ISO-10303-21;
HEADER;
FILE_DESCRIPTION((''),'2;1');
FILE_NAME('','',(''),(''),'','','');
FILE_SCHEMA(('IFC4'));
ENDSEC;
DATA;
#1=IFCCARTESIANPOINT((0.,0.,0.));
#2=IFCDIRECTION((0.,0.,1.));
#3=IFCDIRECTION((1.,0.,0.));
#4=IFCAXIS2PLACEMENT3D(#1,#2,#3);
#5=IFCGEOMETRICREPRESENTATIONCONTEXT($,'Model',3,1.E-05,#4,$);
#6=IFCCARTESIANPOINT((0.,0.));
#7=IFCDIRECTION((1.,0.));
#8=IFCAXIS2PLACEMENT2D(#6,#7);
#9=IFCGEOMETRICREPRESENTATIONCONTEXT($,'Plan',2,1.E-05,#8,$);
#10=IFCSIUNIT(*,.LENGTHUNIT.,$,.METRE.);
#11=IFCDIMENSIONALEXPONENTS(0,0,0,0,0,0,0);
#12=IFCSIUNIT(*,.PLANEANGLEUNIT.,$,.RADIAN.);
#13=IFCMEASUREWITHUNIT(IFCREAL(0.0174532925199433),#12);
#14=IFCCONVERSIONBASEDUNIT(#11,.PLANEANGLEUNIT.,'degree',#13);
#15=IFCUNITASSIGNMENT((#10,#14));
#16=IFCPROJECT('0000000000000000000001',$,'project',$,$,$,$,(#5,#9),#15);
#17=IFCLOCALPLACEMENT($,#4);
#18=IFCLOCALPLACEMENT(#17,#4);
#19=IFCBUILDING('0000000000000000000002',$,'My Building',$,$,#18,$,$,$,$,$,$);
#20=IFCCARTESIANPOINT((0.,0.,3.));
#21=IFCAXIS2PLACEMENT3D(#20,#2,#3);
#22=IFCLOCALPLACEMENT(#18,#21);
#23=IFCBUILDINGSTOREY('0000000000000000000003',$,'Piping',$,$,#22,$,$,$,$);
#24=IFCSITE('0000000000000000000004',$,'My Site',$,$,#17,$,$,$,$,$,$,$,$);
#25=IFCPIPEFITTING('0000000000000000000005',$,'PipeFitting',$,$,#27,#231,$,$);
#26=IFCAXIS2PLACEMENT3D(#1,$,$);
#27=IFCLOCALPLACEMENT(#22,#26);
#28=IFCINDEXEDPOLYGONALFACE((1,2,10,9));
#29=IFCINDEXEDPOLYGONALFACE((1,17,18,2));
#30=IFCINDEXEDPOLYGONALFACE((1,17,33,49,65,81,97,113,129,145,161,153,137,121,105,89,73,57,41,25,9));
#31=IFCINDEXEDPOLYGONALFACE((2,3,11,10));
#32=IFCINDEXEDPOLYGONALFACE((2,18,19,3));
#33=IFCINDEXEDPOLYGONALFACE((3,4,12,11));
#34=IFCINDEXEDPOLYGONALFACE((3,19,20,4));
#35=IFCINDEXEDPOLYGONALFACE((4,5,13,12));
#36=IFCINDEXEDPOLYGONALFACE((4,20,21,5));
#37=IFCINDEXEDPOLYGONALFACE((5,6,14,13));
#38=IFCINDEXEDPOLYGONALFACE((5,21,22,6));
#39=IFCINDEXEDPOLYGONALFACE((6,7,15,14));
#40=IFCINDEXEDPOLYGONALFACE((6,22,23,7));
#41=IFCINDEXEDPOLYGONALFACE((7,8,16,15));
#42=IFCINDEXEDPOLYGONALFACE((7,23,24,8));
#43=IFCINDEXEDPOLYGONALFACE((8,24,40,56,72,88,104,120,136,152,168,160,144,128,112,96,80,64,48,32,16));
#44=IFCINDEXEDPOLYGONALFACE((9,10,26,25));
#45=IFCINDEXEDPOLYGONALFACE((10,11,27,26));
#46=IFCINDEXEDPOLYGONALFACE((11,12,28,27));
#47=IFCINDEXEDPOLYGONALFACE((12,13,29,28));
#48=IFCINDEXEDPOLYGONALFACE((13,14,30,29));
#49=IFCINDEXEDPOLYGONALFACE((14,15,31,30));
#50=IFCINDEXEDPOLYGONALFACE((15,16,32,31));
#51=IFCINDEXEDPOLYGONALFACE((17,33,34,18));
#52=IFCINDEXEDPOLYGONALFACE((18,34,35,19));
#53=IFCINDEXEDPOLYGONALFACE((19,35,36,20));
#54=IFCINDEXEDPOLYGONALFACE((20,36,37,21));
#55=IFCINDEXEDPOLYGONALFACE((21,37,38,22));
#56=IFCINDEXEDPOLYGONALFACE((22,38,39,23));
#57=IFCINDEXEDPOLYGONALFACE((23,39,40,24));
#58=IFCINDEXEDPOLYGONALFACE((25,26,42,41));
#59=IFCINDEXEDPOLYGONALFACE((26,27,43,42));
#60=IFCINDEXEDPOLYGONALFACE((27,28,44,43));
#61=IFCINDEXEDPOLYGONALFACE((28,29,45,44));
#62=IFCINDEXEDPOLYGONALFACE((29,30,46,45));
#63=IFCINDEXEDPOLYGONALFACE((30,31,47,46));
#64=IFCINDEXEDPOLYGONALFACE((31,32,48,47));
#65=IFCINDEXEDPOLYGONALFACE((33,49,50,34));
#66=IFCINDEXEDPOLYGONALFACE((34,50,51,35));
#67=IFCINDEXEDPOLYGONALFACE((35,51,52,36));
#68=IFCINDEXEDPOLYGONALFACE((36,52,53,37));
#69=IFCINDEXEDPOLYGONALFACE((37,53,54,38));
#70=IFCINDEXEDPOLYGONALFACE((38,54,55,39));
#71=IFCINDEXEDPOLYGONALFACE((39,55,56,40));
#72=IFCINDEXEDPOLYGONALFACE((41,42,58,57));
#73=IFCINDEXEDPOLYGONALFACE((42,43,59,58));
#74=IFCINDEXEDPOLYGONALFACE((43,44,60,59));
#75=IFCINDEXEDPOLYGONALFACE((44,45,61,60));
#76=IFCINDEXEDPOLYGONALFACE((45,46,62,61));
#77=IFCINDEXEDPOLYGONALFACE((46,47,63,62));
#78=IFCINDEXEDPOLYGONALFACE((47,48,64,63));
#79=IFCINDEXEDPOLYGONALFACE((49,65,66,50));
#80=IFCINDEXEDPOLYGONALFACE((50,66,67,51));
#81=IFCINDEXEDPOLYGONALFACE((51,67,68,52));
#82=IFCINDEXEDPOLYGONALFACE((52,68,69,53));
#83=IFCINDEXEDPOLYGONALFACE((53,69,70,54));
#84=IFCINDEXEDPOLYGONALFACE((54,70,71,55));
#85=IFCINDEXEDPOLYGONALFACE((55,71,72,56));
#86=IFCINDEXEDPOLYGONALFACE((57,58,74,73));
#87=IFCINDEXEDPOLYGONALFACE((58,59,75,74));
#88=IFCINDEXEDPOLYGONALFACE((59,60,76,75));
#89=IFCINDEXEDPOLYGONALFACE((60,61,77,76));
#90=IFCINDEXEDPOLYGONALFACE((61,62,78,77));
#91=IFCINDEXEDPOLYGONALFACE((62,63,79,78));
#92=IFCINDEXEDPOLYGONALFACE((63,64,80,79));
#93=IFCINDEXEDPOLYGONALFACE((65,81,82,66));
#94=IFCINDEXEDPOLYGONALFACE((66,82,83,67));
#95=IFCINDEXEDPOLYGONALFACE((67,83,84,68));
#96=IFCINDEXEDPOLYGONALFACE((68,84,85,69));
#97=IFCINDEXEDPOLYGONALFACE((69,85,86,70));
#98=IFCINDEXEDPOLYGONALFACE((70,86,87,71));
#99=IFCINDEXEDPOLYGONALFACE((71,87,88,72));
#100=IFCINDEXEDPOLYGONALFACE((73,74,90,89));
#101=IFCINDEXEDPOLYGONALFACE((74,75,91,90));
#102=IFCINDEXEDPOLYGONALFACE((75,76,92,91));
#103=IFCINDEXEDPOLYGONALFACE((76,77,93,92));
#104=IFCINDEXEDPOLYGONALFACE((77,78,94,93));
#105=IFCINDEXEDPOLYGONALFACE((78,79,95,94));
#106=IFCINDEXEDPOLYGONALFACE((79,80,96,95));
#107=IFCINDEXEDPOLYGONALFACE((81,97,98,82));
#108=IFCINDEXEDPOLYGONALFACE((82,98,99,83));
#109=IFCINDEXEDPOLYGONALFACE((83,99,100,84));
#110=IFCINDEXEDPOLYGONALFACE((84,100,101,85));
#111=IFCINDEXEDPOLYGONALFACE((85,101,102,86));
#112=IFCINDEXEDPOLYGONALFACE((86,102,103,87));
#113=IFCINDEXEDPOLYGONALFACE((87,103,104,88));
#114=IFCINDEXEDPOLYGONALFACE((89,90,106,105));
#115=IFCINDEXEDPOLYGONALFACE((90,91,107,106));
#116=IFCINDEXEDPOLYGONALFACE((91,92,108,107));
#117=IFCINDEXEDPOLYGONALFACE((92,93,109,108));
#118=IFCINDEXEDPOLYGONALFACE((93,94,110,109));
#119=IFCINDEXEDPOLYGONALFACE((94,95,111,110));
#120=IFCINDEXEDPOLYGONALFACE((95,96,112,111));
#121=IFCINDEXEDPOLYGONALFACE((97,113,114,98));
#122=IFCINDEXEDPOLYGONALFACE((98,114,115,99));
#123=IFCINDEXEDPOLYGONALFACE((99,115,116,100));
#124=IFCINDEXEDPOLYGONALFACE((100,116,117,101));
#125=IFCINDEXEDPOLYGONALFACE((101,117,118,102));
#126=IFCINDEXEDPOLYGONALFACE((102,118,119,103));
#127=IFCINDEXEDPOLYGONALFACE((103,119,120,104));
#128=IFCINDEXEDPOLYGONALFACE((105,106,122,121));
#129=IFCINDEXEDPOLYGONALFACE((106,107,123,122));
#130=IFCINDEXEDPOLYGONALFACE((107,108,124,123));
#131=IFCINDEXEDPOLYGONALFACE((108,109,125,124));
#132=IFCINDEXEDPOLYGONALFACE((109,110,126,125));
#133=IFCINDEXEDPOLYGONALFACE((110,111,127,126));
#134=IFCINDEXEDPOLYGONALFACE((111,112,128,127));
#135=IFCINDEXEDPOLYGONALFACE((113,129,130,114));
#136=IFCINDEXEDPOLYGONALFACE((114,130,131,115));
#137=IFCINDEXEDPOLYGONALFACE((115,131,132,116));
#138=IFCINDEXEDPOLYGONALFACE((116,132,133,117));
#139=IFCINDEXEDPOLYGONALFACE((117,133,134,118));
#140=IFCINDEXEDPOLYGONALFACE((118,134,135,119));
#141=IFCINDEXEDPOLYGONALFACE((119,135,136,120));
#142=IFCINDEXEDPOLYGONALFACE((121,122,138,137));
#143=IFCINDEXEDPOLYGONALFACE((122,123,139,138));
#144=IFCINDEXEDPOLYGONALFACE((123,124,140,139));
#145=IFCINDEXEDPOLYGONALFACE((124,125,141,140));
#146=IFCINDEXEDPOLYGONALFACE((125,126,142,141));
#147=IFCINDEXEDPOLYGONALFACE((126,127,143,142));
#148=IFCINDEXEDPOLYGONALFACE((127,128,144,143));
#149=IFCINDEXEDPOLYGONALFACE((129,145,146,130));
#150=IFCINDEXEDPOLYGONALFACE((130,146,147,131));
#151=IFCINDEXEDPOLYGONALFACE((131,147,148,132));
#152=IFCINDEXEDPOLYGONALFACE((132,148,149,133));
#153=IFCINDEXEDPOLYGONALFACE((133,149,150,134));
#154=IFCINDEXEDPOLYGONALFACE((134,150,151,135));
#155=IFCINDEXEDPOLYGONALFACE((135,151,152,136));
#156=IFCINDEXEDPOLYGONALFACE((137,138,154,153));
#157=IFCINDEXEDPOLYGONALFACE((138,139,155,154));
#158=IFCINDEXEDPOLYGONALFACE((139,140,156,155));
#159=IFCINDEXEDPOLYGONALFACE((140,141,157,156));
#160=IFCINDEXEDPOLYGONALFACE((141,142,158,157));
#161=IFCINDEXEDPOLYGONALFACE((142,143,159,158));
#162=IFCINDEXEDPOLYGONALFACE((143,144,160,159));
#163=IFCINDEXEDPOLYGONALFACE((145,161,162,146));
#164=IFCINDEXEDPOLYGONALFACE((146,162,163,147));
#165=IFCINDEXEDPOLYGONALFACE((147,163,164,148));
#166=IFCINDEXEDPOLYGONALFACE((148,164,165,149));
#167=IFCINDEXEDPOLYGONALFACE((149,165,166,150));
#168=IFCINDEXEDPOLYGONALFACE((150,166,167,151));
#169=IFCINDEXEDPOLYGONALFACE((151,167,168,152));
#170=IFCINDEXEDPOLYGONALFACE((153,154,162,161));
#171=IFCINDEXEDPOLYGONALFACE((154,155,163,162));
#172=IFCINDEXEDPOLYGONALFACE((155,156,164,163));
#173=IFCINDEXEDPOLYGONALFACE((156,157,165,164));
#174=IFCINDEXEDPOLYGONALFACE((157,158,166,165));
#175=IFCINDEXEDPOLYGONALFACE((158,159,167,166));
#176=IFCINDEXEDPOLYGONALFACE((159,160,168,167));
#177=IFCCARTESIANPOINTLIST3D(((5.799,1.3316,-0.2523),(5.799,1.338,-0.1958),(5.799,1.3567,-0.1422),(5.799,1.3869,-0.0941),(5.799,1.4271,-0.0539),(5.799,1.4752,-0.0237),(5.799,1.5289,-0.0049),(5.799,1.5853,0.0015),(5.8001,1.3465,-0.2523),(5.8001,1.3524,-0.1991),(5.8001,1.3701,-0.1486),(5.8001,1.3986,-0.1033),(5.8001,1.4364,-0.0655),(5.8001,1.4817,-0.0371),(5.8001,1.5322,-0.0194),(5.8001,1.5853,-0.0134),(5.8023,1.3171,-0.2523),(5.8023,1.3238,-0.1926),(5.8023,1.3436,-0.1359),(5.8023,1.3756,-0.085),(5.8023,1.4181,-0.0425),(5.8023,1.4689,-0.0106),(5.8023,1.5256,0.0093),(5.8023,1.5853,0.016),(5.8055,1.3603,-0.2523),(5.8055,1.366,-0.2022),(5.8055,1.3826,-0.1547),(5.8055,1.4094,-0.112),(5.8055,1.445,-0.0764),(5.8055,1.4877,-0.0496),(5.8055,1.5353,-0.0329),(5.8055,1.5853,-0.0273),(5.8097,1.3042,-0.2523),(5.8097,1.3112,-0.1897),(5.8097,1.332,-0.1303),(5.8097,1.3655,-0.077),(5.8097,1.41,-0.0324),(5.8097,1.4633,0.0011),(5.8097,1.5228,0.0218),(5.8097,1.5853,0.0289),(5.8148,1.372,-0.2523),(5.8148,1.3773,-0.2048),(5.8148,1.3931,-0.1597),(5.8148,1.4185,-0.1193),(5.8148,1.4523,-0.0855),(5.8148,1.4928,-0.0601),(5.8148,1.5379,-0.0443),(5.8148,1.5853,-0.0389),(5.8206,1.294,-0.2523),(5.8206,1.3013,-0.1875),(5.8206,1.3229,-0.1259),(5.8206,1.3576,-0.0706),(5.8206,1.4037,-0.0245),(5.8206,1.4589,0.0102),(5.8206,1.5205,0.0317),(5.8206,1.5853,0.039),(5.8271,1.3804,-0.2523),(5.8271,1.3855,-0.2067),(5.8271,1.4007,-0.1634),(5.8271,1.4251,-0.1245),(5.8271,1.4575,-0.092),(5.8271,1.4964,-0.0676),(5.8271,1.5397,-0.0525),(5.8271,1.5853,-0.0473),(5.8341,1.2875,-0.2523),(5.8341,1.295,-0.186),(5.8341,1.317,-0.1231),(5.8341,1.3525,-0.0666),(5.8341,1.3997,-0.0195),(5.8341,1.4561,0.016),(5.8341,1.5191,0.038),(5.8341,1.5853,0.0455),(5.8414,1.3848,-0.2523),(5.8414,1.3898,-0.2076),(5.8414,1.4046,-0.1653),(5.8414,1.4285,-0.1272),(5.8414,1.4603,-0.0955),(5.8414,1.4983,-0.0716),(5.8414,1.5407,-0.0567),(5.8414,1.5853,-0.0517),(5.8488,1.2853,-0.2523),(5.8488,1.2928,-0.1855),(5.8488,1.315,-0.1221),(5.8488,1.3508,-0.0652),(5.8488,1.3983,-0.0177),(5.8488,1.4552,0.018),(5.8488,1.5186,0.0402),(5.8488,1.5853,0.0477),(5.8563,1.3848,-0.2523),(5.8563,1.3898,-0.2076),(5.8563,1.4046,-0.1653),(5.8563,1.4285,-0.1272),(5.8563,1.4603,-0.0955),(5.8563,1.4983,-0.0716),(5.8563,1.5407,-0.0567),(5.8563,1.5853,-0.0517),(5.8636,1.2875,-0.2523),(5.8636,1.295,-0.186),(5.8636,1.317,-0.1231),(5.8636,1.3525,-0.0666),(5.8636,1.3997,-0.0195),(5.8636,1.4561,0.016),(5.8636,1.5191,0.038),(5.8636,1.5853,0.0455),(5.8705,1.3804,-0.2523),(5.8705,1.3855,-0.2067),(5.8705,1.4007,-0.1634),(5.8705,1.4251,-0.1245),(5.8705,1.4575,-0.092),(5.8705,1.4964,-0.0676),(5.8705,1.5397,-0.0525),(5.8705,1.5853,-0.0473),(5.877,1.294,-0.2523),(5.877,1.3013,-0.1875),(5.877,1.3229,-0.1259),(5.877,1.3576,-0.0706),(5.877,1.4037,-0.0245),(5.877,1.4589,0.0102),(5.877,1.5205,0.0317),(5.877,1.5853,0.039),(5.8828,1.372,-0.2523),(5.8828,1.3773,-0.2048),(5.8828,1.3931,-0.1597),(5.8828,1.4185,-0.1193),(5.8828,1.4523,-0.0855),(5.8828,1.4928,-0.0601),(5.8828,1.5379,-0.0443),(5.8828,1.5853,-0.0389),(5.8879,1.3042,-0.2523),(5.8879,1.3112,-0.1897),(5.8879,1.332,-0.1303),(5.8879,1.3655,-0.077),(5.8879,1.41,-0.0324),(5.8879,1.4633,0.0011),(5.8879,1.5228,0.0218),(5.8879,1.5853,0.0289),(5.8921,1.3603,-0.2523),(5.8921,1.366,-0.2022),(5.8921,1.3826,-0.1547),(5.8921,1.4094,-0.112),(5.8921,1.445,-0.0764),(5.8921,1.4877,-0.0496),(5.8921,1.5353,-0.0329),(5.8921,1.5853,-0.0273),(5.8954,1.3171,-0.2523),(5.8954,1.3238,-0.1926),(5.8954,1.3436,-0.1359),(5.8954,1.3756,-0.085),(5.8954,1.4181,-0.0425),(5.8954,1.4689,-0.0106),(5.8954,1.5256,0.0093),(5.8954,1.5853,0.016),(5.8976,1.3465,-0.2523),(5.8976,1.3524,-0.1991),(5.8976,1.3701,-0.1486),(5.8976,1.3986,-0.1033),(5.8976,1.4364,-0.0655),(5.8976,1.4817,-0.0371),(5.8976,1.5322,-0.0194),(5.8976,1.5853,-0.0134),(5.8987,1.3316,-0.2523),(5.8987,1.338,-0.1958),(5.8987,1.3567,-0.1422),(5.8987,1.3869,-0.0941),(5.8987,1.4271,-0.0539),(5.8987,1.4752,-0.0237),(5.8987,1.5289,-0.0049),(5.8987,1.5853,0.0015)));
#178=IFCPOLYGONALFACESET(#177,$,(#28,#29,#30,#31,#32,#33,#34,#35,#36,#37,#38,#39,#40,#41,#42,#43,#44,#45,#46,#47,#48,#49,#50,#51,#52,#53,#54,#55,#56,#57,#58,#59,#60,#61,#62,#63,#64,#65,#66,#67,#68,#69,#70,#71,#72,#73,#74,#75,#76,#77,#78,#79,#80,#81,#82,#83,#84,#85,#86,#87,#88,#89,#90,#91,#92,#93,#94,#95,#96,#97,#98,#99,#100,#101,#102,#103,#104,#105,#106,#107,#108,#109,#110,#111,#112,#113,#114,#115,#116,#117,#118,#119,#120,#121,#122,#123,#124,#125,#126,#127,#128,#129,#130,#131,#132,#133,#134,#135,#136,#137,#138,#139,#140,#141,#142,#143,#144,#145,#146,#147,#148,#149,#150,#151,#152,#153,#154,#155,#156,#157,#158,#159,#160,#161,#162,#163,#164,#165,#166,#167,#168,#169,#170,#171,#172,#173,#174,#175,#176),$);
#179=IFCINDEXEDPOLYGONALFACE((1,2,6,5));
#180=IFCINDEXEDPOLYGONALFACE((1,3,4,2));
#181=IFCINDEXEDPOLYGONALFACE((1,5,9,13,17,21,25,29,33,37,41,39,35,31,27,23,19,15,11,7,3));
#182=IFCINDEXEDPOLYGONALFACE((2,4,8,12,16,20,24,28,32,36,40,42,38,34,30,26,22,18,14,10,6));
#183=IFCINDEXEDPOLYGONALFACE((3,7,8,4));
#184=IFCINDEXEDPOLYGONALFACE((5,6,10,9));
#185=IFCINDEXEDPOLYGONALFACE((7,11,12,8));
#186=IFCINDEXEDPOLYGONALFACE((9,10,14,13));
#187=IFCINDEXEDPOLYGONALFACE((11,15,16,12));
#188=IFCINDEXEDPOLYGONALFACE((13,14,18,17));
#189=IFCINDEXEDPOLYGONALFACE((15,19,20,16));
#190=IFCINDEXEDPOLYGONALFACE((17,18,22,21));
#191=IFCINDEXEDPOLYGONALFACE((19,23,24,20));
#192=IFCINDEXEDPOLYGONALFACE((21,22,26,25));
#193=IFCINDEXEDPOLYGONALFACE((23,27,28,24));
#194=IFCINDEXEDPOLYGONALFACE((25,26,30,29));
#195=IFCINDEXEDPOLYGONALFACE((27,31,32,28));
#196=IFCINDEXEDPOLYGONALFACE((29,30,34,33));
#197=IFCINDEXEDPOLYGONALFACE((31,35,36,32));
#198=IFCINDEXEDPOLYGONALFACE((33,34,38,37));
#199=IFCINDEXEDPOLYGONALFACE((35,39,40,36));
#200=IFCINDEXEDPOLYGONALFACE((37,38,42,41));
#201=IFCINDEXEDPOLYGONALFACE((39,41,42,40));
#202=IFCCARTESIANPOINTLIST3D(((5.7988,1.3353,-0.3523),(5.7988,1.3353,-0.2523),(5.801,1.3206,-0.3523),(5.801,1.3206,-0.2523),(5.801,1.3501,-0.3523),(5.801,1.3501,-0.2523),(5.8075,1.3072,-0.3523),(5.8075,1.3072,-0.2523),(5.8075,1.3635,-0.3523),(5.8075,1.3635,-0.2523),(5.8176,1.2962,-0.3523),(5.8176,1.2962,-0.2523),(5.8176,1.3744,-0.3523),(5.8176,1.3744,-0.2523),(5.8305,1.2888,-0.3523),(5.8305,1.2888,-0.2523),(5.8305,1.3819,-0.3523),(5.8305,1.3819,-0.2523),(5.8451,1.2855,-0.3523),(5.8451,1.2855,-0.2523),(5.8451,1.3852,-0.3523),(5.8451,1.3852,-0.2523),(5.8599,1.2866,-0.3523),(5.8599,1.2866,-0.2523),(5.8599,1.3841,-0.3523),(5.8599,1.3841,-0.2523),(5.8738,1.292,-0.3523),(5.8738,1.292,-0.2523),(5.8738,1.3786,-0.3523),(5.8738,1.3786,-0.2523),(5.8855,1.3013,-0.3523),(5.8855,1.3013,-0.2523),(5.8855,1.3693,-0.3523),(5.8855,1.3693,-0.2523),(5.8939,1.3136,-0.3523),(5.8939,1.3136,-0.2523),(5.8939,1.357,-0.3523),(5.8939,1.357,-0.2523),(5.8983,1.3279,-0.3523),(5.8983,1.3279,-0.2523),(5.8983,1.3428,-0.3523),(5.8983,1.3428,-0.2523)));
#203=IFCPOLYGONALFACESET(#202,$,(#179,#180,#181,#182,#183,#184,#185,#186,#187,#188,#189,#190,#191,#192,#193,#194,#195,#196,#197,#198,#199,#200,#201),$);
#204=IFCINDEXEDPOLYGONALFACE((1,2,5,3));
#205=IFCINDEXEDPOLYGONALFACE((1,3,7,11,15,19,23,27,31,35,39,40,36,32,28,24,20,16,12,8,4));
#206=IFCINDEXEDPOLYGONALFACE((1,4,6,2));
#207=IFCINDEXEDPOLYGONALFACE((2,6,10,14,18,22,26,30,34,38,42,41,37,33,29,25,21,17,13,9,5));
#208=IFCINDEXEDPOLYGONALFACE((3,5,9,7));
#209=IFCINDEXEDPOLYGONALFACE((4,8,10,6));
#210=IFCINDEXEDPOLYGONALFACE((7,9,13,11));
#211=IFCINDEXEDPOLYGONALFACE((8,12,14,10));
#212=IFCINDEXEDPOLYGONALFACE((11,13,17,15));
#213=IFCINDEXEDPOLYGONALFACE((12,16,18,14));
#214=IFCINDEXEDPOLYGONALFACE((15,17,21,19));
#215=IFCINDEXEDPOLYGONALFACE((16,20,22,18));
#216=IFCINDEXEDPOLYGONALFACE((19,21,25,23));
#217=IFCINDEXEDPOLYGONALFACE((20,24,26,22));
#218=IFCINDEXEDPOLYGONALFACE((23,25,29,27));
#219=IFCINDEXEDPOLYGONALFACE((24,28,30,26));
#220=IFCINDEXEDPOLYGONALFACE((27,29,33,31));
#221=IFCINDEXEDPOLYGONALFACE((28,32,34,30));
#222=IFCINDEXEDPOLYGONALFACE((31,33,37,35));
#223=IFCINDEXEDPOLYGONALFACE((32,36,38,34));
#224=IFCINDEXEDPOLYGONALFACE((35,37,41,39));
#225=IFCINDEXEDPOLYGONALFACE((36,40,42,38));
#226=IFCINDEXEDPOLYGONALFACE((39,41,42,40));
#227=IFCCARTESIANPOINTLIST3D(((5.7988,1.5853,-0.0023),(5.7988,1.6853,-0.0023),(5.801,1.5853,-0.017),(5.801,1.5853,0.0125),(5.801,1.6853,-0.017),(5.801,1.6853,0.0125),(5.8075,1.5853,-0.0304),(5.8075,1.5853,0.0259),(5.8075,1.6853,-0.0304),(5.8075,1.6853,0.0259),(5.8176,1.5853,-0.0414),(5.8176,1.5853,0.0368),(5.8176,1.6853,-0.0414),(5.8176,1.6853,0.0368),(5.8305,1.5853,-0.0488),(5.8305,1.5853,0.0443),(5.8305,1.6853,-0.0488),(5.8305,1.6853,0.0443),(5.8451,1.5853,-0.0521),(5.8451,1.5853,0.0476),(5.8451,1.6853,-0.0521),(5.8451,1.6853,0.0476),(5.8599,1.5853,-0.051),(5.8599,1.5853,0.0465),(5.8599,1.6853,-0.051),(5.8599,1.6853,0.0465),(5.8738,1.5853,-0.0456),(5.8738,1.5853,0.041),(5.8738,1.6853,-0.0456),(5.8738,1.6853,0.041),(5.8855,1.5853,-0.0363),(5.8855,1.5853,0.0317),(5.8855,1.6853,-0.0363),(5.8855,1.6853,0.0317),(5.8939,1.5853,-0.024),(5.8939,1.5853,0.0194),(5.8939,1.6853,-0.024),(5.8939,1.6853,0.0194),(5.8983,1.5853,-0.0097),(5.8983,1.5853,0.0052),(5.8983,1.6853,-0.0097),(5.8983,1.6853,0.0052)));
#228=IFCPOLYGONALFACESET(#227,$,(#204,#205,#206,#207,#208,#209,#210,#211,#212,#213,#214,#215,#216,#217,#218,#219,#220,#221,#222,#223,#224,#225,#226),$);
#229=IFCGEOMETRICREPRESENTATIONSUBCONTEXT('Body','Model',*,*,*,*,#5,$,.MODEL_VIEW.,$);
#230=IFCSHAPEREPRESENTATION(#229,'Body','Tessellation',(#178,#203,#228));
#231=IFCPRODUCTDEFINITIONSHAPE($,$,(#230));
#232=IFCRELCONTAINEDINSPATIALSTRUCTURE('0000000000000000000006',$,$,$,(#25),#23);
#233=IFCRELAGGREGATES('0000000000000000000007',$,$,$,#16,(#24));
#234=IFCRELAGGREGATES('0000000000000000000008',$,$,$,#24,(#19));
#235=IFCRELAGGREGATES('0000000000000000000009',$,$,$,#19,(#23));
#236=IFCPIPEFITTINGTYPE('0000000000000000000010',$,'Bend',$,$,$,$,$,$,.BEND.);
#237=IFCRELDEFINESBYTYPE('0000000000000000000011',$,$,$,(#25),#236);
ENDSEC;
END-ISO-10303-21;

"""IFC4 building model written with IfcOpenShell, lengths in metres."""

from ifc_helpers import new_model, entity, si_unit, converted_unit, frame, origin_with_axes, origin_2d_with_axis, place, context, subcontext, project, spatial, circle, extrude, source, transform, mapped, type_object, type_shapes, element, save


model = new_model("IFC4")

# Units and contexts
model_context = context("Model", 3, precision=1e-05, world=origin_with_axes())
plan_context = context("Plan", 2, precision=1e-05, world=origin_2d_with_axis())
body_context = subcontext(model_context, "Body", "Model", "MODEL_VIEW")
ifc_project = project(units=[si_unit("LENGTHUNIT", "METRE"), converted_unit("PLANEANGLEUNIT", "degree", entity("IfcReal", 0.0174532925199433), si_unit("PLANEANGLEUNIT", "RADIAN"), dimensions=[0, 0, 0, 0, 0, 0, 0])], contexts=[model_context, plan_context])

# Site, building, storey
site_placement = place(None, origin_with_axes())
site = spatial("IfcSite", under=ifc_project, at=site_placement, Name="My Site")
building_placement = place(site_placement, origin_with_axes())
building = spatial("IfcBuilding", under=site, at=building_placement, Name="My Building")
storey_placement = place(building_placement, frame((0.0, 0.0, 3.0), z_axis=(0.0, 0.0, 1.0), x_axis=(1.0, 0.0, 0.0)))
storey = spatial("IfcBuildingStorey", under=building, at=storey_placement, Name="Piping")

# Pipe fitting
pipe_fitting_type_1 = type_object("IfcPipeFittingType", Name="Bend", PredefinedType="BEND")
shared_shape = source(origin_with_axes(), body_context, "Body", "SolidModel", [
    entity("IfcSweptDiskSolid", entity("IfcIndexedPolyCurve", entity("IfcCartesianPointList3D", [[0.0, 0.0, -0.1], [0.0, 0.0732, -0.2768], [0.0, 0.25, -0.35]]), [entity("IfcArcIndex", [1, 2, 3])]), 0.05),
    extrude(circle(Radius=0.05), origin_with_axes(), (0.0, 0.0, -1.0), 0.1),
    extrude(circle(Radius=0.05), frame((0.0, 0.25, -0.35), z_axis=(0.0, 1.0, 0.0), x_axis=(1.0, 0.0, 0.0)), (0.0, 0.0, 1.0), 0.1),
])
type_shapes(pipe_fitting_type_1, [shared_shape])
for number, where, z_axis, x_axis, name in (
    (1, (5.8488, 1.3353, -0.3523), (0.0, 0.0, -1.0), (-1.0, 0.0, 0.0), "PipeFitting"),
):
    element("IfcPipeFitting", number, at=place(storey_placement, frame(where, z_axis=z_axis, x_axis=x_axis)), inside=storey, type_object=pipe_fitting_type_1, Name=name, context=body_context, shape_type="MappedRepresentation", body=[
        mapped(shared_shape, transform((0.0, 0.0, 0.0), x_axis=(1.0, 0.0, 0.0), y_axis=(0.0, 1.0, 0.0), z_axis=(0.0, 0.0, 1.0), scale=1.0)),
    ])

save(model, "model.ifc")
